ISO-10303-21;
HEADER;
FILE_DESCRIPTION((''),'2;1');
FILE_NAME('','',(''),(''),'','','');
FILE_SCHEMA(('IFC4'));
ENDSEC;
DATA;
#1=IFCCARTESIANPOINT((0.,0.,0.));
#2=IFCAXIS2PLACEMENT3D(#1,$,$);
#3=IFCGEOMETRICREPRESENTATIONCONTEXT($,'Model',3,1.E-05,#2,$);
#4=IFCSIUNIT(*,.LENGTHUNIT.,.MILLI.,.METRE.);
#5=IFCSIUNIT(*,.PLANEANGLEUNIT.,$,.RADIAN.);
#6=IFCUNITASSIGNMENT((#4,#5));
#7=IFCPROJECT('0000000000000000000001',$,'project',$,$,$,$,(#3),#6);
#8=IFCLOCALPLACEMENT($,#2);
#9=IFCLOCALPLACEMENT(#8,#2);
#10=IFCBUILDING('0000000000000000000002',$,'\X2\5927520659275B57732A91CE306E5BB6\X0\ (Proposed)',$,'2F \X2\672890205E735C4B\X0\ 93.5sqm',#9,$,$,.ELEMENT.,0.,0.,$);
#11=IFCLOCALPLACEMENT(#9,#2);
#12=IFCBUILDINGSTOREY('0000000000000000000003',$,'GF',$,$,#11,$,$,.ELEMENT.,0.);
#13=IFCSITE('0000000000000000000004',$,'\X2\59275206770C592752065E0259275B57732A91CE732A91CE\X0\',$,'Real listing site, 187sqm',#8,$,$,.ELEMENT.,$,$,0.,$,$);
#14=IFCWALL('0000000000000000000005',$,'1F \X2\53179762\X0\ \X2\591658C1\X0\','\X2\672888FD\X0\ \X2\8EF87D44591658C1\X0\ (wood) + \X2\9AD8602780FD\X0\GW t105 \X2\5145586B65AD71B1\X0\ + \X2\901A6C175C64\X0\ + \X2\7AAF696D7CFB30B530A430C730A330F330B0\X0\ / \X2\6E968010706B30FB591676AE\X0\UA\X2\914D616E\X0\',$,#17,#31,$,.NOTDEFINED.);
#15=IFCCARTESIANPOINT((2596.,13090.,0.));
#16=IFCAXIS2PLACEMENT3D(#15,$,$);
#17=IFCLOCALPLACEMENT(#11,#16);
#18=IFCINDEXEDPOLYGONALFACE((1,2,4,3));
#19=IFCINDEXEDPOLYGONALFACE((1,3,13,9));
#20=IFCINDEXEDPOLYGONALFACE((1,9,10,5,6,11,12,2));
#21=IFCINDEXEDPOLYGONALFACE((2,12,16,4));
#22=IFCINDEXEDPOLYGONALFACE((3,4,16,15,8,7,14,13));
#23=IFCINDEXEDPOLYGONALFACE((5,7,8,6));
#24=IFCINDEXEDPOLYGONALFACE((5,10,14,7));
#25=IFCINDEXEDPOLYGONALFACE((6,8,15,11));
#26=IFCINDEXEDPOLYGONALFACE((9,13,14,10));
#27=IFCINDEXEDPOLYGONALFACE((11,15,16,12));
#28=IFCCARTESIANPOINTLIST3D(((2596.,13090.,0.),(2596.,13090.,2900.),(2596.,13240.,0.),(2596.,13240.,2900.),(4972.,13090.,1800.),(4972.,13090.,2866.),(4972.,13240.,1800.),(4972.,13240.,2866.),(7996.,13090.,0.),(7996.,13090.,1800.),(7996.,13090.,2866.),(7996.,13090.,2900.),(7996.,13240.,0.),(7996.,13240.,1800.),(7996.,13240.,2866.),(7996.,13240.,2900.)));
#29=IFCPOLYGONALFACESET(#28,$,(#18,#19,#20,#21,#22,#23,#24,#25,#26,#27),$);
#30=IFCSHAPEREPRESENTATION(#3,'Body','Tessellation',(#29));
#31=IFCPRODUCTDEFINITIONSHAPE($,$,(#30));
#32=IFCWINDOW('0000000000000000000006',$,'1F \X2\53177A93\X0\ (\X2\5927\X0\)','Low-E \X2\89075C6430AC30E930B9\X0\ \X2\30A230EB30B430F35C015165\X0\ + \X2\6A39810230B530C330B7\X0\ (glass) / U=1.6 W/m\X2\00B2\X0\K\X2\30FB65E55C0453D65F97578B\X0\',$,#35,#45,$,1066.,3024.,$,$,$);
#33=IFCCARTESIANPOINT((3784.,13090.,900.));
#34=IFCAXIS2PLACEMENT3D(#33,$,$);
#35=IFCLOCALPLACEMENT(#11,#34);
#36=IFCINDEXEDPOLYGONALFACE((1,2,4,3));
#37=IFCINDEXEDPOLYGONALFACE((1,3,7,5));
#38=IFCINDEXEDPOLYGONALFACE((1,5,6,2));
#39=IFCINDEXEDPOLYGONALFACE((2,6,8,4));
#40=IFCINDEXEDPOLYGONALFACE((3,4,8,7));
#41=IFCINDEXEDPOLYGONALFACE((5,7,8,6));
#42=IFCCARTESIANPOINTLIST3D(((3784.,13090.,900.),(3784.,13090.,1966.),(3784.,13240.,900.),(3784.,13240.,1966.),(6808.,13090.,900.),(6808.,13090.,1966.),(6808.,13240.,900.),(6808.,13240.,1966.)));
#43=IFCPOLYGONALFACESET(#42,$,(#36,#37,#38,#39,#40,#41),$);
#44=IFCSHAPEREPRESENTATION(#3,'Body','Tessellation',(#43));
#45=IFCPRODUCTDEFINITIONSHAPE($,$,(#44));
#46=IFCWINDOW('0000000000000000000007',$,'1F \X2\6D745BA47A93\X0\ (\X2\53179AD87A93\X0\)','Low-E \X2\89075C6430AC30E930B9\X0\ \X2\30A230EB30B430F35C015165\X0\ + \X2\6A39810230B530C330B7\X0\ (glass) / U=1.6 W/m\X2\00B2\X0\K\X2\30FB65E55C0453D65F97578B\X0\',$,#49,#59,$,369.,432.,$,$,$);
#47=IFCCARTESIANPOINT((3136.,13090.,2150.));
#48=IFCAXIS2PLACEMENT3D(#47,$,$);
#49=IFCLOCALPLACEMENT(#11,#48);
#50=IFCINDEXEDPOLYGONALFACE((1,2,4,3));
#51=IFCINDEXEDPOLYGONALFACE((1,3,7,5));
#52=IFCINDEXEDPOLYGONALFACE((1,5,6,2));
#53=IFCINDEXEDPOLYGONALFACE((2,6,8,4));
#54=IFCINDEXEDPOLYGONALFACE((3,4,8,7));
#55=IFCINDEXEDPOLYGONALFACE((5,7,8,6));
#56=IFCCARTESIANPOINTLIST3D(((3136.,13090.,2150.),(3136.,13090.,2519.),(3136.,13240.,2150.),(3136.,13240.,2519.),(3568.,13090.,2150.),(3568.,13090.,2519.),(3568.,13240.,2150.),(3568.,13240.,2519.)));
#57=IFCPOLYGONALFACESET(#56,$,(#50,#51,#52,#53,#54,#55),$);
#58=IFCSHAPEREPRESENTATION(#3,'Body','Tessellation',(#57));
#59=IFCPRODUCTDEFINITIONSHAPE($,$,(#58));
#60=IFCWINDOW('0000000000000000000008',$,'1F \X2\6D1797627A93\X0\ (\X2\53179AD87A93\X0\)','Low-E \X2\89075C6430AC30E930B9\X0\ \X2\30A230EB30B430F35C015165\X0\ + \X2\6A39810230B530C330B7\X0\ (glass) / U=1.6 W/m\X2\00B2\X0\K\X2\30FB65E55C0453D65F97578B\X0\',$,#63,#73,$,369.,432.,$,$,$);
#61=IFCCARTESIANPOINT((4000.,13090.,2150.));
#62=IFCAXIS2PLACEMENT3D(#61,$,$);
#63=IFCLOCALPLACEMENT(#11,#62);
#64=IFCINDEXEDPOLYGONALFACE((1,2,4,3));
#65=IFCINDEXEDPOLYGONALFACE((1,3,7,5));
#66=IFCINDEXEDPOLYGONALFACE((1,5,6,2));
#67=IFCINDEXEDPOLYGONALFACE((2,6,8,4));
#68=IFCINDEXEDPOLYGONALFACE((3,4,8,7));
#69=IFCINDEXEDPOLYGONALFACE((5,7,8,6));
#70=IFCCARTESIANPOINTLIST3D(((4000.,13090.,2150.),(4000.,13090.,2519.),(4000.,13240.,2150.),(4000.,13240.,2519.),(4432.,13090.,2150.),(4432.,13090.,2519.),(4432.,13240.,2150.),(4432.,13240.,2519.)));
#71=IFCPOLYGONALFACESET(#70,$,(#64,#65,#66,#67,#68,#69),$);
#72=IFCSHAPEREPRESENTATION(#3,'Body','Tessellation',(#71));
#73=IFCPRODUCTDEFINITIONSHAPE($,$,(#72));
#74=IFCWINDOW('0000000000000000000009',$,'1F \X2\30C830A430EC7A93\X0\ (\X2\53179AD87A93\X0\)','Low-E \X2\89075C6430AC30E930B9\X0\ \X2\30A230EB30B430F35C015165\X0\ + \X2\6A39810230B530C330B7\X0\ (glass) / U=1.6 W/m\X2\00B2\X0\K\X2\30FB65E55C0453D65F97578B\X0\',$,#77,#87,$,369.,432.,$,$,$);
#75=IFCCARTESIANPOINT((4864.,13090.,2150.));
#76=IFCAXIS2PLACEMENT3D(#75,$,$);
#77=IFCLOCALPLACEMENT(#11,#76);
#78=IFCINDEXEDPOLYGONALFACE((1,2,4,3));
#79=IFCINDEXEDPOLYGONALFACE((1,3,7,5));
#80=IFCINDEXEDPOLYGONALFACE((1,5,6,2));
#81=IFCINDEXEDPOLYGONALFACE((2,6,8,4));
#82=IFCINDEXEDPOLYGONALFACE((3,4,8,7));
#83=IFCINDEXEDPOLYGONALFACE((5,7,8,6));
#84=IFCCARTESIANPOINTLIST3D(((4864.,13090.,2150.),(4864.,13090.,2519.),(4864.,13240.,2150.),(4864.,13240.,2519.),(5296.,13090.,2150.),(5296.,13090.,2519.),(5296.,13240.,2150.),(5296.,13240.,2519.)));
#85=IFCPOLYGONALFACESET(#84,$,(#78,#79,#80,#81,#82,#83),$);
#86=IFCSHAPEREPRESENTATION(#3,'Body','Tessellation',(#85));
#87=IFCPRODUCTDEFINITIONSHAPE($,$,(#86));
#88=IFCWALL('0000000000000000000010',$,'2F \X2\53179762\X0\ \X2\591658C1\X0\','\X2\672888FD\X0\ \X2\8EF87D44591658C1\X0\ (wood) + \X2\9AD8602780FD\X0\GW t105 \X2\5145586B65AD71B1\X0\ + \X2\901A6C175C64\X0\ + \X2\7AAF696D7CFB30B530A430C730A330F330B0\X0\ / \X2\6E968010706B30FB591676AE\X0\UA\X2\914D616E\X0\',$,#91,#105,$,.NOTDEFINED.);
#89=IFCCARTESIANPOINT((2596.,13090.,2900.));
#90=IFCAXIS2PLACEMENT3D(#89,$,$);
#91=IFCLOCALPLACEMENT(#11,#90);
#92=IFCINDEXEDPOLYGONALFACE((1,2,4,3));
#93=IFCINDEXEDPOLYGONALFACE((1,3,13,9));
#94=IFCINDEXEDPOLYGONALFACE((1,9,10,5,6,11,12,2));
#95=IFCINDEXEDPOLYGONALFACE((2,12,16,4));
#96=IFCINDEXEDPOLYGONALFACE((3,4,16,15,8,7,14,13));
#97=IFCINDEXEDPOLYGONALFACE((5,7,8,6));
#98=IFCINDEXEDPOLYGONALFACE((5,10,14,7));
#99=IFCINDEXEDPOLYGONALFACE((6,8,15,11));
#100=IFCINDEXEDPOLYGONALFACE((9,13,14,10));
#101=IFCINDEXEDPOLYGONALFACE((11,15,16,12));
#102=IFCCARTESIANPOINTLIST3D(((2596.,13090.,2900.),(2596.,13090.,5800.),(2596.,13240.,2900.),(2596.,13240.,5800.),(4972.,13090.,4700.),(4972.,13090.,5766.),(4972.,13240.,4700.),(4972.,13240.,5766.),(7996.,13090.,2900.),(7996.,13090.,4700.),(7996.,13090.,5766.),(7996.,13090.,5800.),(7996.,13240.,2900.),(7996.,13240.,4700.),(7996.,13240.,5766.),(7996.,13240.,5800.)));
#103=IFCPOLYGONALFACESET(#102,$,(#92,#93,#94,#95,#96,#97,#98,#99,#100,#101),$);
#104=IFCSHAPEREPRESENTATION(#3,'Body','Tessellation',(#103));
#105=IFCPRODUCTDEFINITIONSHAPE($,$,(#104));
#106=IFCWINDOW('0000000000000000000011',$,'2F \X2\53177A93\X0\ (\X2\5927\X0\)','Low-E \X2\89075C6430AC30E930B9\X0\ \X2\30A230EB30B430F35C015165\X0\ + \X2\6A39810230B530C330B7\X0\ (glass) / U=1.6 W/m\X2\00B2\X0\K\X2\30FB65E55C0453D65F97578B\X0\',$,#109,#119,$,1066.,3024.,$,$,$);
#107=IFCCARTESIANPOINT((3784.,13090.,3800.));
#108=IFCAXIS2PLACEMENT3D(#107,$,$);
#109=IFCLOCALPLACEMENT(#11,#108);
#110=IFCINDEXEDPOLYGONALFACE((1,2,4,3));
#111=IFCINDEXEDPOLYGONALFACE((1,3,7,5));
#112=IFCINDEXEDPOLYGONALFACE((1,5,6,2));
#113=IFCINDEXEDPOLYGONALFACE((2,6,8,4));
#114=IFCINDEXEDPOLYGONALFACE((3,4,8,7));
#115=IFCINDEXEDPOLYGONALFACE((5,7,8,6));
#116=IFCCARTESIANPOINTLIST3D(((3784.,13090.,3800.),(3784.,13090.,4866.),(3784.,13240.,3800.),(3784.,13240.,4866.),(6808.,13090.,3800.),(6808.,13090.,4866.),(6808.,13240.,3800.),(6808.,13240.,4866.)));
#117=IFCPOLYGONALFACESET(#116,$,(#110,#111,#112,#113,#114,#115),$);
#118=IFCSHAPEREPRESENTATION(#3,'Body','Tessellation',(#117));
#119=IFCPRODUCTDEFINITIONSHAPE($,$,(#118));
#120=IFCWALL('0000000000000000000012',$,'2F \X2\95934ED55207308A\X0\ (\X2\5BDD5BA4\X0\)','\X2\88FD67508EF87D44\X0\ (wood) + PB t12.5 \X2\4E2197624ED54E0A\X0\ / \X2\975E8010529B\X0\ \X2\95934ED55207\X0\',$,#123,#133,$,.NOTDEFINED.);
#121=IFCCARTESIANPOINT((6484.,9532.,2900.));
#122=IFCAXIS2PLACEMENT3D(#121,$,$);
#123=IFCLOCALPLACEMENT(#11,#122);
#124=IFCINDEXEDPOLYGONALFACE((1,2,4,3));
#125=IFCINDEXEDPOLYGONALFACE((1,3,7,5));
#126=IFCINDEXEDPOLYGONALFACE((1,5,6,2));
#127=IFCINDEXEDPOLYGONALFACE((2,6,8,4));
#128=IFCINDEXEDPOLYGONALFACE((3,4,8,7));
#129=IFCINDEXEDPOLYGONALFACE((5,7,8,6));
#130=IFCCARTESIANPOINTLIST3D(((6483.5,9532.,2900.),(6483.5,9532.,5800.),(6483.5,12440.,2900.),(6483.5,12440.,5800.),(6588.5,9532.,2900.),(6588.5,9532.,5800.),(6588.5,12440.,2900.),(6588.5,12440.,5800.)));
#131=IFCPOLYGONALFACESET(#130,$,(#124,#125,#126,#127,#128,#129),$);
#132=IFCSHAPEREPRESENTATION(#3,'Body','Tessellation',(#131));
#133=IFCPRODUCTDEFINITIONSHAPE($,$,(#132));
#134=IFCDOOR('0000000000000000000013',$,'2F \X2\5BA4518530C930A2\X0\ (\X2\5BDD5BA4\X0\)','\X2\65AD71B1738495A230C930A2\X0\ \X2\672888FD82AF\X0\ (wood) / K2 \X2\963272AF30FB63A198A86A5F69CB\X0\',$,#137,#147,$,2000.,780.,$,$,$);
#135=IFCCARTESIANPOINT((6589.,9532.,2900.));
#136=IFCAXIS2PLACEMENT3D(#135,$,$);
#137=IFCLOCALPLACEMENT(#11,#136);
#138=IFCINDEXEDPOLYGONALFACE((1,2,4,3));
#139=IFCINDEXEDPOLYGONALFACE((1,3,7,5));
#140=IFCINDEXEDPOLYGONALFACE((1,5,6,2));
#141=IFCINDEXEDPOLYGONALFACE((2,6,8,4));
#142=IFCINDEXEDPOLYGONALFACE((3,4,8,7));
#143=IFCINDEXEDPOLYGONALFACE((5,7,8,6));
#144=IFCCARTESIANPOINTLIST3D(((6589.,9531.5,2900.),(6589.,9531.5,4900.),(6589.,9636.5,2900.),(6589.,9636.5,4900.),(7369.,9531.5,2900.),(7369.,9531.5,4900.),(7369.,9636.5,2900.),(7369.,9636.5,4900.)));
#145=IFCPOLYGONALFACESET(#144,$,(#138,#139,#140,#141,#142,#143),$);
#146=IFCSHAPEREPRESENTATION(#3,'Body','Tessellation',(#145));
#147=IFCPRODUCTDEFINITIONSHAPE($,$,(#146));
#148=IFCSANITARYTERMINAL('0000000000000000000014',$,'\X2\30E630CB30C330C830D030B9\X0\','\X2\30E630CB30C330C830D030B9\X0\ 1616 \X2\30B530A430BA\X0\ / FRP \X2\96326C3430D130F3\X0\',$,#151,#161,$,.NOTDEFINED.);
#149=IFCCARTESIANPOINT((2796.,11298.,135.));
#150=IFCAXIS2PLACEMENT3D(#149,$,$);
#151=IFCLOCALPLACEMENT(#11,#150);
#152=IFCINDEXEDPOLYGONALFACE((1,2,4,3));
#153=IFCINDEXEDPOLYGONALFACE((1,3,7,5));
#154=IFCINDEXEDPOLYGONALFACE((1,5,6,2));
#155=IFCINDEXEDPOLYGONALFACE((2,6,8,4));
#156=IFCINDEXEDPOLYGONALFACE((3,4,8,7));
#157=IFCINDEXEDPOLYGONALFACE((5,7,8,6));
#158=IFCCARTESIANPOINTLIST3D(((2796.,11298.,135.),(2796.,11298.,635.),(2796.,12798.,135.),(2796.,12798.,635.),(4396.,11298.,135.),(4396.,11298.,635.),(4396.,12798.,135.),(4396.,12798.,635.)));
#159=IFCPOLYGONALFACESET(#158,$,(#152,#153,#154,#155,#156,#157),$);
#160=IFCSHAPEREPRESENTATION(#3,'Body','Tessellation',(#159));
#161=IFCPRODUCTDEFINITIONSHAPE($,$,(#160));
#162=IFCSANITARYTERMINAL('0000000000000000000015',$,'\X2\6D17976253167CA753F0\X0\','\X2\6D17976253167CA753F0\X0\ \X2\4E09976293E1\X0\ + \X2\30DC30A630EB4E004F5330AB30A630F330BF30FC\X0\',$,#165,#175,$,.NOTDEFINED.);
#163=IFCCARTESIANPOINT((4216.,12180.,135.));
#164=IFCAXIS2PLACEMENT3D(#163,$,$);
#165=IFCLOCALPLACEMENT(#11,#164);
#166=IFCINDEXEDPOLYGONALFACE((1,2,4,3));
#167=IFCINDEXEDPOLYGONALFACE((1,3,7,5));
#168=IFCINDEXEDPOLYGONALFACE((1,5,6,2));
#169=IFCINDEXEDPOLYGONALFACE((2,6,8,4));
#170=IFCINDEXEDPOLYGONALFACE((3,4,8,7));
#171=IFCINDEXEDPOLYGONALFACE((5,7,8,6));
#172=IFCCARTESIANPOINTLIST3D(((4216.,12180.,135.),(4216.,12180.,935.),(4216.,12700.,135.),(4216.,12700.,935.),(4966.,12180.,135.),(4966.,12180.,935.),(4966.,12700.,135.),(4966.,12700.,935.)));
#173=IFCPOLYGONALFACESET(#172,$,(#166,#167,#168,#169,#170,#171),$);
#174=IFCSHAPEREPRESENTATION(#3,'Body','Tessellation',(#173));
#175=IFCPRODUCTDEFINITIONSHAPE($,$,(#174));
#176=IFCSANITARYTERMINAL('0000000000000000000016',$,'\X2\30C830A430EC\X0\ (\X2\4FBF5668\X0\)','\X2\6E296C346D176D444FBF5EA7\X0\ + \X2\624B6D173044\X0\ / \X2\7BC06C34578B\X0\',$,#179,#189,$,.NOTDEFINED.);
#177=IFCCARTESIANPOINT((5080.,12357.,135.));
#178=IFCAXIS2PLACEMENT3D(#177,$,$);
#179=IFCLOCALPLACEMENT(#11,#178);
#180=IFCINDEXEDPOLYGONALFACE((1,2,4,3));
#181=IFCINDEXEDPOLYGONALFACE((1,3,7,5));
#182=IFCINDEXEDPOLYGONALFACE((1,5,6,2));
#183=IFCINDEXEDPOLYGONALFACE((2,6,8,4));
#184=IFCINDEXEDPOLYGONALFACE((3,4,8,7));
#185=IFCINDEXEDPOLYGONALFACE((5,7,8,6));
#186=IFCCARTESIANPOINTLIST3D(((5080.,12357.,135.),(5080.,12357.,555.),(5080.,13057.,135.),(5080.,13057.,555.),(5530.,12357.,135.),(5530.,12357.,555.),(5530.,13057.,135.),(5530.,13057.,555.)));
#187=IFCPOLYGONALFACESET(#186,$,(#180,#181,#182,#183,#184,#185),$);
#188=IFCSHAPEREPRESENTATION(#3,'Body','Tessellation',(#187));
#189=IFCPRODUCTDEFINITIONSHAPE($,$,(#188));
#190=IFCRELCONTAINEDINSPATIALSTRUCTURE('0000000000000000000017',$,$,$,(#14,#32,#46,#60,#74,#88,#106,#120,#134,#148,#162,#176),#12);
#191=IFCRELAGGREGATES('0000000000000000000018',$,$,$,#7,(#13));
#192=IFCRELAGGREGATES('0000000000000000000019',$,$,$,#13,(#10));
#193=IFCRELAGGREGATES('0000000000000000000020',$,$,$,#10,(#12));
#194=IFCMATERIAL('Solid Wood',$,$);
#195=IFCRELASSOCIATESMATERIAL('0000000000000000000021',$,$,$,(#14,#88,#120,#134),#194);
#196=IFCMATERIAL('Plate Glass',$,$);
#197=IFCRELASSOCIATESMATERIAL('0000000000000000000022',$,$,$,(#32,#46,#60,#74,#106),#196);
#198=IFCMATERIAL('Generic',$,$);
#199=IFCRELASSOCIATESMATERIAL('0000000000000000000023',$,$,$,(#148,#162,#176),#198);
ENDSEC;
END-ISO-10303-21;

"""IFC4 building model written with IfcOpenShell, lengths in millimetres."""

from ifc_helpers import new_model, si_unit, frame, frame_2d, origin, place, context, project, spatial, rectangle, extrude, material, element, fill, save


model = new_model("IFC4")

# Units and contexts
model_context = context("Model", 3, precision=1e-05, world=origin())
ifc_project = project(units=[si_unit("LENGTHUNIT", "METRE", prefix="MILLI"), si_unit("PLANEANGLEUNIT", "RADIAN")], contexts=[model_context])

# Site, building, storey
site_placement = place(None, origin())
site = spatial("IfcSite", under=ifc_project, at=site_placement, Name="大分県大分市大字猪野猪野", ObjectType="Real listing site, 187sqm", CompositionType="ELEMENT", RefElevation=0.0)
building_placement = place(site_placement, origin())
building = spatial("IfcBuilding", under=site, at=building_placement, Name="大分大字猪野の家 (Proposed)", ObjectType="2F 木造平屋 93.5sqm", CompositionType="ELEMENT", ElevationOfRefHeight=0.0, ElevationOfTerrain=0.0)
storey_placement = place(building_placement, origin())
storey = spatial("IfcBuildingStorey", under=building, at=storey_placement, Name="GF", CompositionType="ELEMENT", Elevation=0.0)

# Wall, openings, windows
ifc_material_1 = material(Name="Solid Wood")
wall_1_placement = place(storey_placement, frame((2596.0, 13090.0, 0.0)))
wall_1 = element("IfcWall", 1, at=wall_1_placement, inside=storey, material=ifc_material_1, Name="1F 北面 外壁", Description="木製 軸組外壁 (wood) + 高性能GW t105 充填断熱 + 通気層 + 窯業系サイディング / 準耐火・外皮UA配慮", PredefinedType="NOTDEFINED", context=model_context, shape_type="SweptSolid", body=[
    extrude(rectangle(XDim=5400.0, YDim=150.0, at=frame_2d((2700.0, 75.0))), frame((2596.0, 13090.0, 0.0)), (0.0, 0.0, 1.0), 2900.0),
])
opening_1_placement = place(storey_placement, frame((3784.0, 13090.0, 900.0)))
opening_1 = element("IfcOpeningElement", 2, at=opening_1_placement, cuts=wall_1, PredefinedType="NOTDEFINED", context=model_context, shape_type="SweptSolid", body=[
    extrude(rectangle(XDim=3024.0, YDim=150.0, at=frame_2d((1512.0, 75.0))), frame((3784.0, 13090.0, 900.0)), (0.0, 0.0, 1.0), 1066.0),
])
opening_2_placement = place(storey_placement, frame((3136.0, 13090.0, 2150.0)))
opening_2 = element("IfcOpeningElement", 3, at=opening_2_placement, cuts=wall_1, PredefinedType="NOTDEFINED", context=model_context, shape_type="SweptSolid", body=[
    extrude(rectangle(XDim=432.0, YDim=150.0, at=frame_2d((216.0, 75.0))), frame((3136.0, 13090.0, 2150.0)), (0.0, 0.0, 1.0), 369.0),
])
opening_3_placement = place(storey_placement, frame((4000.0, 13090.0, 2150.0)))
opening_3 = element("IfcOpeningElement", 4, at=opening_3_placement, cuts=wall_1, PredefinedType="NOTDEFINED", context=model_context, shape_type="SweptSolid", body=[
    extrude(rectangle(XDim=432.0, YDim=150.0, at=frame_2d((216.0, 75.0))), frame((4000.0, 13090.0, 2150.0)), (0.0, 0.0, 1.0), 369.0),
])
opening_4_placement = place(storey_placement, frame((4864.0, 13090.0, 2150.0)))
opening_4 = element("IfcOpeningElement", 5, at=opening_4_placement, cuts=wall_1, PredefinedType="NOTDEFINED", context=model_context, shape_type="SweptSolid", body=[
    extrude(rectangle(XDim=432.0, YDim=150.0, at=frame_2d((216.0, 75.0))), frame((4864.0, 13090.0, 2150.0)), (0.0, 0.0, 1.0), 369.0),
])
ifc_material_2 = material(Name="Plate Glass")
window_1_placement = place(storey_placement, frame((3784.0, 13090.0, 900.0)))
window_1 = element("IfcWindow", 6, at=window_1_placement, inside=storey, material=ifc_material_2, Name="1F 北窓 (大)", Description="Low-E 複層ガラス アルゴン封入 + 樹脂サッシ (glass) / U=1.6 W/m²K・日射取得型", OverallHeight=1066.0, OverallWidth=3024.0, context=model_context, shape_type="SweptSolid", body=[
    extrude(rectangle(XDim=3024.0, YDim=150.0, at=frame_2d((1512.0, 75.0))), frame((3784.0, 13090.0, 900.0)), (0.0, 0.0, 1.0), 1066.0),
])
fill(opening_1, window_1)
window_2_placement = place(storey_placement, frame((3136.0, 13090.0, 2150.0)))
window_2 = element("IfcWindow", 7, at=window_2_placement, inside=storey, material=ifc_material_2, Name="1F 浴室窓 (北高窓)", Description="Low-E 複層ガラス アルゴン封入 + 樹脂サッシ (glass) / U=1.6 W/m²K・日射取得型", OverallHeight=369.0, OverallWidth=432.0, context=model_context, shape_type="SweptSolid", body=[
    extrude(rectangle(XDim=432.0, YDim=150.0, at=frame_2d((216.0, 75.0))), frame((3136.0, 13090.0, 2150.0)), (0.0, 0.0, 1.0), 369.0),
])
fill(opening_2, window_2)
window_3_placement = place(storey_placement, frame((4000.0, 13090.0, 2150.0)))
window_3 = element("IfcWindow", 8, at=window_3_placement, inside=storey, material=ifc_material_2, Name="1F 洗面窓 (北高窓)", Description="Low-E 複層ガラス アルゴン封入 + 樹脂サッシ (glass) / U=1.6 W/m²K・日射取得型", OverallHeight=369.0, OverallWidth=432.0, context=model_context, shape_type="SweptSolid", body=[
    extrude(rectangle(XDim=432.0, YDim=150.0, at=frame_2d((216.0, 75.0))), frame((4000.0, 13090.0, 2150.0)), (0.0, 0.0, 1.0), 369.0),
])
fill(opening_3, window_3)
window_4_placement = place(storey_placement, frame((4864.0, 13090.0, 2150.0)))
window_4 = element("IfcWindow", 9, at=window_4_placement, inside=storey, material=ifc_material_2, Name="1F トイレ窓 (北高窓)", Description="Low-E 複層ガラス アルゴン封入 + 樹脂サッシ (glass) / U=1.6 W/m²K・日射取得型", OverallHeight=369.0, OverallWidth=432.0, context=model_context, shape_type="SweptSolid", body=[
    extrude(rectangle(XDim=432.0, YDim=150.0, at=frame_2d((216.0, 75.0))), frame((4864.0, 13090.0, 2150.0)), (0.0, 0.0, 1.0), 369.0),
])
fill(opening_4, window_4)

# Wall, opening, window
wall_2_placement = place(storey_placement, frame((2596.0, 13090.0, 2900.0)))
wall_2 = element("IfcWall", 10, at=wall_2_placement, inside=storey, material=ifc_material_1, Name="2F 北面 外壁", Description="木製 軸組外壁 (wood) + 高性能GW t105 充填断熱 + 通気層 + 窯業系サイディング / 準耐火・外皮UA配慮", PredefinedType="NOTDEFINED", context=model_context, shape_type="SweptSolid", body=[
    extrude(rectangle(XDim=5400.0, YDim=150.0, at=frame_2d((2700.0, 75.0))), frame((2596.0, 13090.0, 2900.0)), (0.0, 0.0, 1.0), 2900.0),
])
opening_5_placement = place(storey_placement, frame((3784.0, 13090.0, 3800.0)))
opening_5 = element("IfcOpeningElement", 11, at=opening_5_placement, cuts=wall_2, PredefinedType="NOTDEFINED", context=model_context, shape_type="SweptSolid", body=[
    extrude(rectangle(XDim=3024.0, YDim=150.0, at=frame_2d((1512.0, 75.0))), frame((3784.0, 13090.0, 3800.0)), (0.0, 0.0, 1.0), 1066.0),
])
window_5_placement = place(storey_placement, frame((3784.0, 13090.0, 3800.0)))
window_5 = element("IfcWindow", 12, at=window_5_placement, inside=storey, material=ifc_material_2, Name="2F 北窓 (大)", Description="Low-E 複層ガラス アルゴン封入 + 樹脂サッシ (glass) / U=1.6 W/m²K・日射取得型", OverallHeight=1066.0, OverallWidth=3024.0, context=model_context, shape_type="SweptSolid", body=[
    extrude(rectangle(XDim=3024.0, YDim=150.0, at=frame_2d((1512.0, 75.0))), frame((3784.0, 13090.0, 3800.0)), (0.0, 0.0, 1.0), 1066.0),
])
fill(opening_5, window_5)

# Wall
wall_3_placement = place(storey_placement, frame((6484.0, 9532.0, 2900.0)))
element("IfcWall", 13, at=wall_3_placement, inside=storey, material=ifc_material_1, Name="2F 間仕切り (寝室)", Description="製材軸組 (wood) + PB t12.5 両面仕上 / 非耐力 間仕切", PredefinedType="NOTDEFINED", context=model_context, shape_type="SweptSolid", body=[
    extrude(rectangle(XDim=105.0, YDim=2908.0, at=frame_2d((52.0, 1454.0))), frame((6484.0, 9532.0, 2900.0)), (0.0, 0.0, 1.0), 2900.0),
])

# Door
door_1_placement = place(storey_placement, frame((6589.0, 9532.0, 2900.0)))
element("IfcDoor", 14, at=door_1_placement, inside=storey, material=ifc_material_1, Name="2F 室内ドア (寝室)", Description="断熱玄関ドア 木製芯 (wood) / K2 防犯・採風機構", OverallHeight=2000.0, OverallWidth=780.0, context=model_context, shape_type="SweptSolid", body=[
    extrude(rectangle(XDim=780.0, YDim=105.0, at=frame_2d((390.0, 52.0))), frame((6589.0, 9532.0, 2900.0)), (0.0, 0.0, 1.0), 2000.0),
])

# Sanitary terminals
ifc_material_3 = material(Name="Generic")
sanitary_terminal_1_placement = place(storey_placement, frame((2796.0, 11298.0, 135.0)))
element("IfcSanitaryTerminal", 15, at=sanitary_terminal_1_placement, inside=storey, material=ifc_material_3, Name="ユニットバス", Description="ユニットバス 1616 サイズ / FRP 防水パン", PredefinedType="NOTDEFINED", context=model_context, shape_type="SweptSolid", body=[
    extrude(rectangle(XDim=1600.0, YDim=1500.0, at=frame_2d((800.0, 750.0))), frame((2796.0, 11298.0, 135.0)), (0.0, 0.0, 1.0), 500.0),
])
sanitary_terminal_2_placement = place(storey_placement, frame((4216.0, 12180.0, 135.0)))
element("IfcSanitaryTerminal", 16, at=sanitary_terminal_2_placement, inside=storey, material=ifc_material_3, Name="洗面化粧台", Description="洗面化粧台 三面鏡 + ボウル一体カウンター", PredefinedType="NOTDEFINED", context=model_context, shape_type="SweptSolid", body=[
    extrude(rectangle(XDim=750.0, YDim=520.0, at=frame_2d((375.0, 260.0))), frame((4216.0, 12180.0, 135.0)), (0.0, 0.0, 1.0), 800.0),
])
sanitary_terminal_3_placement = place(storey_placement, frame((5080.0, 12357.0, 135.0)))
element("IfcSanitaryTerminal", 17, at=sanitary_terminal_3_placement, inside=storey, material=ifc_material_3, Name="トイレ (便器)", Description="温水洗浄便座 + 手洗い / 節水型", PredefinedType="NOTDEFINED", context=model_context, shape_type="SweptSolid", body=[
    extrude(rectangle(XDim=450.0, YDim=700.0, at=frame_2d((225.0, 350.0))), frame((5080.0, 12357.0, 135.0)), (0.0, 0.0, 1.0), 420.0),
])

save(model, "model.ifc")
